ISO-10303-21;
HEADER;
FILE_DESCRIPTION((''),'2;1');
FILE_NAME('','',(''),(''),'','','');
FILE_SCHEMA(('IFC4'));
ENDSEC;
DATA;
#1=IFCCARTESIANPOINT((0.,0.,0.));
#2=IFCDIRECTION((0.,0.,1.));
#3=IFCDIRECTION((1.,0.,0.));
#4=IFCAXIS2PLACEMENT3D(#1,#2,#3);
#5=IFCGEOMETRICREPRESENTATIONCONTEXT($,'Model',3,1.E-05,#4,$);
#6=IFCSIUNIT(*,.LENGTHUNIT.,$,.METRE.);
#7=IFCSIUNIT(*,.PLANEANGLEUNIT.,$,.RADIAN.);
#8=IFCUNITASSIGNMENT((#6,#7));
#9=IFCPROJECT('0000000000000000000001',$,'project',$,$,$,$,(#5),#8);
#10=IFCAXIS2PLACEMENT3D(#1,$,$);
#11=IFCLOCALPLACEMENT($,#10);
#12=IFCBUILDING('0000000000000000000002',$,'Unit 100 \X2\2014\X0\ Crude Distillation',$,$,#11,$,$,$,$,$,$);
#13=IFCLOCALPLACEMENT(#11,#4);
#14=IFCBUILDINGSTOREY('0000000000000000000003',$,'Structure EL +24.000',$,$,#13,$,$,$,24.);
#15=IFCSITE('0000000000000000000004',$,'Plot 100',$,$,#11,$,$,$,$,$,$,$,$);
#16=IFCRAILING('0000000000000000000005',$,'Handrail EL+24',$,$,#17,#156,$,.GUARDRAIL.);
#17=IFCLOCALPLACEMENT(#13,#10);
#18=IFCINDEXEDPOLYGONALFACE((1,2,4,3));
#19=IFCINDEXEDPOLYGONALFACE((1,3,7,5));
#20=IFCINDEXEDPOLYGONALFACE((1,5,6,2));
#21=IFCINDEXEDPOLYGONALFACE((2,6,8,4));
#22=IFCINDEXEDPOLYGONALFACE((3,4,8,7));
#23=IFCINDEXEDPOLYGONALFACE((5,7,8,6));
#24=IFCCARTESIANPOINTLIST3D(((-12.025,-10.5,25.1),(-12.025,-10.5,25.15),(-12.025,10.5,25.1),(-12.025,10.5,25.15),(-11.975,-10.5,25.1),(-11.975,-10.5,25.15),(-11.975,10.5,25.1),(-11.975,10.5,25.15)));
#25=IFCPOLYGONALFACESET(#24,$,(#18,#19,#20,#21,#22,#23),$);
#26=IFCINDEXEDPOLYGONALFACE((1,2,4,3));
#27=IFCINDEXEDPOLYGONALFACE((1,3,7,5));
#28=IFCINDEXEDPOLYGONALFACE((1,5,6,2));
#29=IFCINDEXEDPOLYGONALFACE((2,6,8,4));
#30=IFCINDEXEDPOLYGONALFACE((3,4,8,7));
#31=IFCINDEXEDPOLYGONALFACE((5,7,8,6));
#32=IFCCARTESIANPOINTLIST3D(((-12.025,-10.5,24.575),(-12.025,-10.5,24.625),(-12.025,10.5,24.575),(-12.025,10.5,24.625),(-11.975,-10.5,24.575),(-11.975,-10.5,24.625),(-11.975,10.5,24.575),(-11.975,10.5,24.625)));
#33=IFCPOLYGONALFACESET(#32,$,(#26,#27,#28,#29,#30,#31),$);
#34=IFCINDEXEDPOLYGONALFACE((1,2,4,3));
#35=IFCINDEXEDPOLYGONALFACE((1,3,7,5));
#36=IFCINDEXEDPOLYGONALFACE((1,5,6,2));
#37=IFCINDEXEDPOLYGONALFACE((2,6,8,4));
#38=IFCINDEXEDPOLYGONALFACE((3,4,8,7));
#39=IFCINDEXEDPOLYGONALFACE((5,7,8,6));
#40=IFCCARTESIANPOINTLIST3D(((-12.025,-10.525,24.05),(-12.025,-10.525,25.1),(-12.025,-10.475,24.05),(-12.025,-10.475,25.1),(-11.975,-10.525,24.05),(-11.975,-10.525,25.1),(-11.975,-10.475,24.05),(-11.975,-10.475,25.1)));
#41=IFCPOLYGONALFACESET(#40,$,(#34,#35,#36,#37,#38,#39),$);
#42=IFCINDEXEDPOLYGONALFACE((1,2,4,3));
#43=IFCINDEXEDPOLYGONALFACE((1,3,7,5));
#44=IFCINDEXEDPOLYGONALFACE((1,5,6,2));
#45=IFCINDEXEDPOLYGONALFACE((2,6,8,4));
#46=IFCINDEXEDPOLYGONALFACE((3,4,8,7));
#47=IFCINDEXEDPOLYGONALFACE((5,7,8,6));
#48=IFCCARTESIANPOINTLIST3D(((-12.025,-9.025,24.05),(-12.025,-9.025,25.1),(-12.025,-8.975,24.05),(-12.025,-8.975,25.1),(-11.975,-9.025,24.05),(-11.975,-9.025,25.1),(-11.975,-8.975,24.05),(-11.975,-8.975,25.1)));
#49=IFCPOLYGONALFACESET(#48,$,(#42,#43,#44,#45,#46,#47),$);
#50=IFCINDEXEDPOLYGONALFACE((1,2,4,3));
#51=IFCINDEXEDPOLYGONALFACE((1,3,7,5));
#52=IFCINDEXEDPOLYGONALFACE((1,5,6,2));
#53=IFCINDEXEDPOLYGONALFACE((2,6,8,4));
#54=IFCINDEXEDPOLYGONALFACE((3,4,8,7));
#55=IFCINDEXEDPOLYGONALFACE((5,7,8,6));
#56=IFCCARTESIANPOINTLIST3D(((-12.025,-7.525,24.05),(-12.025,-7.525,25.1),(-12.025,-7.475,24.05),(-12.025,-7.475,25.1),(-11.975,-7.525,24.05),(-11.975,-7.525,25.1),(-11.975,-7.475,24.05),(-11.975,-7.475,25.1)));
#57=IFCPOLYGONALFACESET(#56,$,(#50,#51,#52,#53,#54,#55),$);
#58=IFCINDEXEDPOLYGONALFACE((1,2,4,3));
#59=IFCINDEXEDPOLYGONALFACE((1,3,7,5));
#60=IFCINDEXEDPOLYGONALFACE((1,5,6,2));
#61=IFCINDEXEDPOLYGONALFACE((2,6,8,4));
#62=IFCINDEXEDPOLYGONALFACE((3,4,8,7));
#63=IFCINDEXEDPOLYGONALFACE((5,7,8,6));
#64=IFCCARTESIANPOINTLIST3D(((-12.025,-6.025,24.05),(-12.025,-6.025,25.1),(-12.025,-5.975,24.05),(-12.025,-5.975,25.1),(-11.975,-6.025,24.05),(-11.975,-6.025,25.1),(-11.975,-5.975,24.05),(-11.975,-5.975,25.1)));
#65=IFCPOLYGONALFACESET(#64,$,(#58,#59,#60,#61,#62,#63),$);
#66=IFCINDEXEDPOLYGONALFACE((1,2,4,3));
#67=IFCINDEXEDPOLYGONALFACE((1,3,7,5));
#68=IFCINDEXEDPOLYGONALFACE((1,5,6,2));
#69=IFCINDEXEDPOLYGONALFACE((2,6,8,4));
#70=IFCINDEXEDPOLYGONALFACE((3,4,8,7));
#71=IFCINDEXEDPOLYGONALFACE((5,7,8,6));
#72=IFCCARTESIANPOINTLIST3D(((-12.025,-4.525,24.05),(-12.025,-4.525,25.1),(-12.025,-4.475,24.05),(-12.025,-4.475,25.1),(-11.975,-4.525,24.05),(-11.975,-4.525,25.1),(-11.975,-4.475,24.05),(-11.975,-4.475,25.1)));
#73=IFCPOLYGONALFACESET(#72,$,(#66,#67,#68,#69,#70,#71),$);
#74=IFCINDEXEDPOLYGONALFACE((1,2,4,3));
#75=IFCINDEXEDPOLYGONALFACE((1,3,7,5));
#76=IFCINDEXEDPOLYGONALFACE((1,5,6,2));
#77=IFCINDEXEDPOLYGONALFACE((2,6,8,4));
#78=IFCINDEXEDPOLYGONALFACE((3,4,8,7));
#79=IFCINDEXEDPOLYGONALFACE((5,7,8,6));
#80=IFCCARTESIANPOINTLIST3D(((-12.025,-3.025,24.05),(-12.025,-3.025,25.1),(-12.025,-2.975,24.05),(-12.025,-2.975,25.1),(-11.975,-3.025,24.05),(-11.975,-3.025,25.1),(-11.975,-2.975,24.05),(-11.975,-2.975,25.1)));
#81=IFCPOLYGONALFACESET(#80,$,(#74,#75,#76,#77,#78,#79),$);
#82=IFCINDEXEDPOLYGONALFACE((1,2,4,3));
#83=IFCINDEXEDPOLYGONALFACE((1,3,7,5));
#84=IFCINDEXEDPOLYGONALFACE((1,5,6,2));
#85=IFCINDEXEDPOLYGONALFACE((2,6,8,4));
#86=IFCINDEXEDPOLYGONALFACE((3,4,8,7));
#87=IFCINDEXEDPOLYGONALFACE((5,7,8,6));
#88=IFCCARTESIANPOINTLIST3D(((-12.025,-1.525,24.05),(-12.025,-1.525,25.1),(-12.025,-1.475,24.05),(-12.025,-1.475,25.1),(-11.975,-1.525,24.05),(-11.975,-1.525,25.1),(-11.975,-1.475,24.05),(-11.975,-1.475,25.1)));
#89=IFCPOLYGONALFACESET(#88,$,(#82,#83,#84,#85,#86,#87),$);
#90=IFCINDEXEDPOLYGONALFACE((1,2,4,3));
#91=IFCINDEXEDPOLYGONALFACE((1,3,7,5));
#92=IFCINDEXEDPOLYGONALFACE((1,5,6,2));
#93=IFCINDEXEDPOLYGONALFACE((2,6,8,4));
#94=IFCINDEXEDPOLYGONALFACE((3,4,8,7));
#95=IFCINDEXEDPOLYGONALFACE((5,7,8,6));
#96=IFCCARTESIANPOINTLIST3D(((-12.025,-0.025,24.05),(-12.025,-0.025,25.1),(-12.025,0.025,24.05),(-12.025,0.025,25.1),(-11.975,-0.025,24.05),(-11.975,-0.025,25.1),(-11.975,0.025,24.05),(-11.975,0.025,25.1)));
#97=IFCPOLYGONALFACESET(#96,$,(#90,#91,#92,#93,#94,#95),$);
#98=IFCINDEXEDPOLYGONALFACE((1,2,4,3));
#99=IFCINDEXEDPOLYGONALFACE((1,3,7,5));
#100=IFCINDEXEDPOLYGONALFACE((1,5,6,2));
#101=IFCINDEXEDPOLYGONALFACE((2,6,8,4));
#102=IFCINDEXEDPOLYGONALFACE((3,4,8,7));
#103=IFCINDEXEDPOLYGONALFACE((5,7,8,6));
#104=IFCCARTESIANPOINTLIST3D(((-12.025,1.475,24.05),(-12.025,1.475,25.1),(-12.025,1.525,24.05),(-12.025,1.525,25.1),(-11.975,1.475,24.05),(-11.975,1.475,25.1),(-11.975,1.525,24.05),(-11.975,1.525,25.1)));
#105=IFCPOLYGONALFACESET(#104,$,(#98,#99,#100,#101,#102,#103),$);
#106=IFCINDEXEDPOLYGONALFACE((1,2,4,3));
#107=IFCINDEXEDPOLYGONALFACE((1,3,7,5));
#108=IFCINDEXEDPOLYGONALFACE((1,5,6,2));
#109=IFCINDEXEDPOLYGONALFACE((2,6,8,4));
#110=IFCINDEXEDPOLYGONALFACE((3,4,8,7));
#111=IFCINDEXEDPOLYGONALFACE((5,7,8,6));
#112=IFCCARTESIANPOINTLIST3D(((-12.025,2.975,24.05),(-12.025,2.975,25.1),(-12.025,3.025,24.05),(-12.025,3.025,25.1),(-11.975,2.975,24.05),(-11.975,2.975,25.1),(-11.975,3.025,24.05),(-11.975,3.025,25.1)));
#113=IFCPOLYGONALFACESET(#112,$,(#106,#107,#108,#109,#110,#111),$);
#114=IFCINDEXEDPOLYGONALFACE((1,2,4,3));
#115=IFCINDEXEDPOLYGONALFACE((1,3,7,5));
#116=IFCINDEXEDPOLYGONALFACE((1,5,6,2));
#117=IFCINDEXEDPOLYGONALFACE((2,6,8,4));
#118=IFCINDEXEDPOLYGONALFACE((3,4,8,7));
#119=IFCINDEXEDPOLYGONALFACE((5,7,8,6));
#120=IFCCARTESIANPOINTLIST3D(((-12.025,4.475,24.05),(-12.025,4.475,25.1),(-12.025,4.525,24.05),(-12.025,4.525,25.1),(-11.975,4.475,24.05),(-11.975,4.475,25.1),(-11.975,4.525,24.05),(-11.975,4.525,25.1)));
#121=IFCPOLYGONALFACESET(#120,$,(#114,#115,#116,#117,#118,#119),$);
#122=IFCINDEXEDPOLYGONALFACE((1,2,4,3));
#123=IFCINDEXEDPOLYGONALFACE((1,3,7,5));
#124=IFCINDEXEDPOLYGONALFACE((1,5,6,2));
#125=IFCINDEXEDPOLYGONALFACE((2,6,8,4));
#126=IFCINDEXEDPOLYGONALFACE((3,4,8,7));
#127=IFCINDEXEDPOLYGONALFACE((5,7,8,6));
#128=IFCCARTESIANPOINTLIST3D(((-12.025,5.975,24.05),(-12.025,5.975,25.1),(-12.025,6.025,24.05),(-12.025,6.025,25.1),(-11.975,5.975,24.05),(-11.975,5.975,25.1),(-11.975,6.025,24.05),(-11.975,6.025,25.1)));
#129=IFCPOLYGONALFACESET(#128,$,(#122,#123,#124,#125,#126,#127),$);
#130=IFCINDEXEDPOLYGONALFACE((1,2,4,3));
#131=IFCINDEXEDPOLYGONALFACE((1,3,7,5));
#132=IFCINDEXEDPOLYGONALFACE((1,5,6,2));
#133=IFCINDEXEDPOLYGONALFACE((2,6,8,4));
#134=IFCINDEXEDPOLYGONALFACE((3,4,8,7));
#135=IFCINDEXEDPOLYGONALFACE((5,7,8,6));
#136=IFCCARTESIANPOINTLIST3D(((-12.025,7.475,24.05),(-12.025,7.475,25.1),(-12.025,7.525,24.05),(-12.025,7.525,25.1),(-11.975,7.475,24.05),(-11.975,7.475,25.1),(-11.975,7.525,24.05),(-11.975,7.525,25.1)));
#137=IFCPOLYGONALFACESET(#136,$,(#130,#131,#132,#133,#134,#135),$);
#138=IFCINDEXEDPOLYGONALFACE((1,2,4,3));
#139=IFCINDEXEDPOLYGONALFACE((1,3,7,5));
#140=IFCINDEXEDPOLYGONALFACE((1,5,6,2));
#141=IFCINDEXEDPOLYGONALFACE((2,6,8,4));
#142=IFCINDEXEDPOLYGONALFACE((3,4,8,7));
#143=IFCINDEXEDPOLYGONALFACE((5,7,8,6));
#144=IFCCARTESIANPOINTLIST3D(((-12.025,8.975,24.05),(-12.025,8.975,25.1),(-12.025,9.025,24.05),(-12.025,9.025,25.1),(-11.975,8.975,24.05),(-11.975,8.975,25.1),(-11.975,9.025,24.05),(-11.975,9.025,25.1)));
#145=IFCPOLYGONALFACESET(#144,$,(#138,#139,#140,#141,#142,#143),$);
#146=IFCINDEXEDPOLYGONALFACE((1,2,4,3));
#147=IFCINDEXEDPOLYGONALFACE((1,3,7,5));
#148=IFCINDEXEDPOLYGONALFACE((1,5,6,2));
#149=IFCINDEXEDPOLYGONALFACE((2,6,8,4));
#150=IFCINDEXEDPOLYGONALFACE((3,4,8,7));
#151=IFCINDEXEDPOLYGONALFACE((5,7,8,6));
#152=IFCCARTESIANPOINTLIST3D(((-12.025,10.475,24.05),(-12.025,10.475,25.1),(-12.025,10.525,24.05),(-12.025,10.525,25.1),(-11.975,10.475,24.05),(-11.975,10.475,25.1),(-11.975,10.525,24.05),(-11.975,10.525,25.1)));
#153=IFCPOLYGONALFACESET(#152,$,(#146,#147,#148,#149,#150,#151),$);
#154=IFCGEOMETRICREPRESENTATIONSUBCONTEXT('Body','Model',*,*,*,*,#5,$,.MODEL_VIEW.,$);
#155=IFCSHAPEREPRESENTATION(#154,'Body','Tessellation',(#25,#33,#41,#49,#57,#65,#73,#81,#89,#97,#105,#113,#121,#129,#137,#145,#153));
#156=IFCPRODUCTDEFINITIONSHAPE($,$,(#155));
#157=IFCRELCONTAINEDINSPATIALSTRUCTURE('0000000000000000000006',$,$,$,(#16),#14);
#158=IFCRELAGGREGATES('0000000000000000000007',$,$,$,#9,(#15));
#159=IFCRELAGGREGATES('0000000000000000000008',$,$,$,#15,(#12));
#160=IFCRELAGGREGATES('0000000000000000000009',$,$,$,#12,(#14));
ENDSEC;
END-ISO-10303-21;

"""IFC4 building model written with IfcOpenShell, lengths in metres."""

from ifc_helpers import new_model, si_unit, frame, origin, origin_with_axes, origin_2d, place, context, subcontext, project, spatial, rectangle, extrude, element, save


model = new_model("IFC4")

# Units and contexts
model_context = context("Model", 3, precision=1e-05, world=origin_with_axes())
body_context = subcontext(model_context, "Body", "Model", "MODEL_VIEW")
ifc_project = project(units=[si_unit("LENGTHUNIT", "METRE"), si_unit("PLANEANGLEUNIT", "RADIAN")], contexts=[model_context])

# Site, building, storey
placement = place(None, origin())
site = spatial("IfcSite", under=ifc_project, at=placement, Name="Plot 100")
building = spatial("IfcBuilding", under=site, at=placement, Name="Unit 100 — Crude Distillation")
storey_placement = place(placement, origin_with_axes())
storey = spatial("IfcBuildingStorey", under=building, at=storey_placement, Name="Structure EL +24.000", Elevation=24.0)

# Railing
railing_1_placement = place(storey_placement, origin_with_axes())
element("IfcRailing", 1, at=railing_1_placement, inside=storey, Name="Handrail EL+24", PredefinedType="GUARDRAIL", context=body_context, shape_type="SweptSolid", body=[
    extrude(rectangle(XDim=0.05, YDim=0.05, at=origin_2d()), frame((-12.0, -10.5, 25.125), z_axis=(0.0, 1.0, 0.0), x_axis=(-1.0, 0.0, 0.0)), (0.0, 0.0, 1.0), 21.0),
    extrude(rectangle(XDim=0.05, YDim=0.05, at=origin_2d()), frame((-12.0, -10.5, 24.6), z_axis=(0.0, 1.0, 0.0), x_axis=(-1.0, 0.0, 0.0)), (0.0, 0.0, 1.0), 21.0),
    extrude(rectangle(XDim=0.05, YDim=0.05, at=origin_2d()), frame((-12.0, -10.5, 24.05), z_axis=(0.0, 0.0, 1.0), x_axis=(1.0, 0.0, 0.0)), (0.0, 0.0, 1.0), 1.05),
    extrude(rectangle(XDim=0.05, YDim=0.05, at=origin_2d()), frame((-12.0, -9.0, 24.05), z_axis=(0.0, 0.0, 1.0), x_axis=(1.0, 0.0, 0.0)), (0.0, 0.0, 1.0), 1.05),
    extrude(rectangle(XDim=0.05, YDim=0.05, at=origin_2d()), frame((-12.0, -7.5, 24.05), z_axis=(0.0, 0.0, 1.0), x_axis=(1.0, 0.0, 0.0)), (0.0, 0.0, 1.0), 1.05),
    extrude(rectangle(XDim=0.05, YDim=0.05, at=origin_2d()), frame((-12.0, -6.0, 24.05), z_axis=(0.0, 0.0, 1.0), x_axis=(1.0, 0.0, 0.0)), (0.0, 0.0, 1.0), 1.05),
    extrude(rectangle(XDim=0.05, YDim=0.05, at=origin_2d()), frame((-12.0, -4.5, 24.05), z_axis=(0.0, 0.0, 1.0), x_axis=(1.0, 0.0, 0.0)), (0.0, 0.0, 1.0), 1.05),
    extrude(rectangle(XDim=0.05, YDim=0.05, at=origin_2d()), frame((-12.0, -3.0, 24.05), z_axis=(0.0, 0.0, 1.0), x_axis=(1.0, 0.0, 0.0)), (0.0, 0.0, 1.0), 1.05),
    extrude(rectangle(XDim=0.05, YDim=0.05, at=origin_2d()), frame((-12.0, -1.5, 24.05), z_axis=(0.0, 0.0, 1.0), x_axis=(1.0, 0.0, 0.0)), (0.0, 0.0, 1.0), 1.05),
    extrude(rectangle(XDim=0.05, YDim=0.05, at=origin_2d()), frame((-12.0, 0.0, 24.05), z_axis=(0.0, 0.0, 1.0), x_axis=(1.0, 0.0, 0.0)), (0.0, 0.0, 1.0), 1.05),
    extrude(rectangle(XDim=0.05, YDim=0.05, at=origin_2d()), frame((-12.0, 1.5, 24.05), z_axis=(0.0, 0.0, 1.0), x_axis=(1.0, 0.0, 0.0)), (0.0, 0.0, 1.0), 1.05),
    extrude(rectangle(XDim=0.05, YDim=0.05, at=origin_2d()), frame((-12.0, 3.0, 24.05), z_axis=(0.0, 0.0, 1.0), x_axis=(1.0, 0.0, 0.0)), (0.0, 0.0, 1.0), 1.05),
    extrude(rectangle(XDim=0.05, YDim=0.05, at=origin_2d()), frame((-12.0, 4.5, 24.05), z_axis=(0.0, 0.0, 1.0), x_axis=(1.0, 0.0, 0.0)), (0.0, 0.0, 1.0), 1.05),
    extrude(rectangle(XDim=0.05, YDim=0.05, at=origin_2d()), frame((-12.0, 6.0, 24.05), z_axis=(0.0, 0.0, 1.0), x_axis=(1.0, 0.0, 0.0)), (0.0, 0.0, 1.0), 1.05),
    extrude(rectangle(XDim=0.05, YDim=0.05, at=origin_2d()), frame((-12.0, 7.5, 24.05), z_axis=(0.0, 0.0, 1.0), x_axis=(1.0, 0.0, 0.0)), (0.0, 0.0, 1.0), 1.05),
    extrude(rectangle(XDim=0.05, YDim=0.05, at=origin_2d()), frame((-12.0, 9.0, 24.05), z_axis=(0.0, 0.0, 1.0), x_axis=(1.0, 0.0, 0.0)), (0.0, 0.0, 1.0), 1.05),
    extrude(rectangle(XDim=0.05, YDim=0.05, at=origin_2d()), frame((-12.0, 10.5, 24.05), z_axis=(0.0, 0.0, 1.0), x_axis=(1.0, 0.0, 0.0)), (0.0, 0.0, 1.0), 1.05),
])

save(model, "model.ifc")
